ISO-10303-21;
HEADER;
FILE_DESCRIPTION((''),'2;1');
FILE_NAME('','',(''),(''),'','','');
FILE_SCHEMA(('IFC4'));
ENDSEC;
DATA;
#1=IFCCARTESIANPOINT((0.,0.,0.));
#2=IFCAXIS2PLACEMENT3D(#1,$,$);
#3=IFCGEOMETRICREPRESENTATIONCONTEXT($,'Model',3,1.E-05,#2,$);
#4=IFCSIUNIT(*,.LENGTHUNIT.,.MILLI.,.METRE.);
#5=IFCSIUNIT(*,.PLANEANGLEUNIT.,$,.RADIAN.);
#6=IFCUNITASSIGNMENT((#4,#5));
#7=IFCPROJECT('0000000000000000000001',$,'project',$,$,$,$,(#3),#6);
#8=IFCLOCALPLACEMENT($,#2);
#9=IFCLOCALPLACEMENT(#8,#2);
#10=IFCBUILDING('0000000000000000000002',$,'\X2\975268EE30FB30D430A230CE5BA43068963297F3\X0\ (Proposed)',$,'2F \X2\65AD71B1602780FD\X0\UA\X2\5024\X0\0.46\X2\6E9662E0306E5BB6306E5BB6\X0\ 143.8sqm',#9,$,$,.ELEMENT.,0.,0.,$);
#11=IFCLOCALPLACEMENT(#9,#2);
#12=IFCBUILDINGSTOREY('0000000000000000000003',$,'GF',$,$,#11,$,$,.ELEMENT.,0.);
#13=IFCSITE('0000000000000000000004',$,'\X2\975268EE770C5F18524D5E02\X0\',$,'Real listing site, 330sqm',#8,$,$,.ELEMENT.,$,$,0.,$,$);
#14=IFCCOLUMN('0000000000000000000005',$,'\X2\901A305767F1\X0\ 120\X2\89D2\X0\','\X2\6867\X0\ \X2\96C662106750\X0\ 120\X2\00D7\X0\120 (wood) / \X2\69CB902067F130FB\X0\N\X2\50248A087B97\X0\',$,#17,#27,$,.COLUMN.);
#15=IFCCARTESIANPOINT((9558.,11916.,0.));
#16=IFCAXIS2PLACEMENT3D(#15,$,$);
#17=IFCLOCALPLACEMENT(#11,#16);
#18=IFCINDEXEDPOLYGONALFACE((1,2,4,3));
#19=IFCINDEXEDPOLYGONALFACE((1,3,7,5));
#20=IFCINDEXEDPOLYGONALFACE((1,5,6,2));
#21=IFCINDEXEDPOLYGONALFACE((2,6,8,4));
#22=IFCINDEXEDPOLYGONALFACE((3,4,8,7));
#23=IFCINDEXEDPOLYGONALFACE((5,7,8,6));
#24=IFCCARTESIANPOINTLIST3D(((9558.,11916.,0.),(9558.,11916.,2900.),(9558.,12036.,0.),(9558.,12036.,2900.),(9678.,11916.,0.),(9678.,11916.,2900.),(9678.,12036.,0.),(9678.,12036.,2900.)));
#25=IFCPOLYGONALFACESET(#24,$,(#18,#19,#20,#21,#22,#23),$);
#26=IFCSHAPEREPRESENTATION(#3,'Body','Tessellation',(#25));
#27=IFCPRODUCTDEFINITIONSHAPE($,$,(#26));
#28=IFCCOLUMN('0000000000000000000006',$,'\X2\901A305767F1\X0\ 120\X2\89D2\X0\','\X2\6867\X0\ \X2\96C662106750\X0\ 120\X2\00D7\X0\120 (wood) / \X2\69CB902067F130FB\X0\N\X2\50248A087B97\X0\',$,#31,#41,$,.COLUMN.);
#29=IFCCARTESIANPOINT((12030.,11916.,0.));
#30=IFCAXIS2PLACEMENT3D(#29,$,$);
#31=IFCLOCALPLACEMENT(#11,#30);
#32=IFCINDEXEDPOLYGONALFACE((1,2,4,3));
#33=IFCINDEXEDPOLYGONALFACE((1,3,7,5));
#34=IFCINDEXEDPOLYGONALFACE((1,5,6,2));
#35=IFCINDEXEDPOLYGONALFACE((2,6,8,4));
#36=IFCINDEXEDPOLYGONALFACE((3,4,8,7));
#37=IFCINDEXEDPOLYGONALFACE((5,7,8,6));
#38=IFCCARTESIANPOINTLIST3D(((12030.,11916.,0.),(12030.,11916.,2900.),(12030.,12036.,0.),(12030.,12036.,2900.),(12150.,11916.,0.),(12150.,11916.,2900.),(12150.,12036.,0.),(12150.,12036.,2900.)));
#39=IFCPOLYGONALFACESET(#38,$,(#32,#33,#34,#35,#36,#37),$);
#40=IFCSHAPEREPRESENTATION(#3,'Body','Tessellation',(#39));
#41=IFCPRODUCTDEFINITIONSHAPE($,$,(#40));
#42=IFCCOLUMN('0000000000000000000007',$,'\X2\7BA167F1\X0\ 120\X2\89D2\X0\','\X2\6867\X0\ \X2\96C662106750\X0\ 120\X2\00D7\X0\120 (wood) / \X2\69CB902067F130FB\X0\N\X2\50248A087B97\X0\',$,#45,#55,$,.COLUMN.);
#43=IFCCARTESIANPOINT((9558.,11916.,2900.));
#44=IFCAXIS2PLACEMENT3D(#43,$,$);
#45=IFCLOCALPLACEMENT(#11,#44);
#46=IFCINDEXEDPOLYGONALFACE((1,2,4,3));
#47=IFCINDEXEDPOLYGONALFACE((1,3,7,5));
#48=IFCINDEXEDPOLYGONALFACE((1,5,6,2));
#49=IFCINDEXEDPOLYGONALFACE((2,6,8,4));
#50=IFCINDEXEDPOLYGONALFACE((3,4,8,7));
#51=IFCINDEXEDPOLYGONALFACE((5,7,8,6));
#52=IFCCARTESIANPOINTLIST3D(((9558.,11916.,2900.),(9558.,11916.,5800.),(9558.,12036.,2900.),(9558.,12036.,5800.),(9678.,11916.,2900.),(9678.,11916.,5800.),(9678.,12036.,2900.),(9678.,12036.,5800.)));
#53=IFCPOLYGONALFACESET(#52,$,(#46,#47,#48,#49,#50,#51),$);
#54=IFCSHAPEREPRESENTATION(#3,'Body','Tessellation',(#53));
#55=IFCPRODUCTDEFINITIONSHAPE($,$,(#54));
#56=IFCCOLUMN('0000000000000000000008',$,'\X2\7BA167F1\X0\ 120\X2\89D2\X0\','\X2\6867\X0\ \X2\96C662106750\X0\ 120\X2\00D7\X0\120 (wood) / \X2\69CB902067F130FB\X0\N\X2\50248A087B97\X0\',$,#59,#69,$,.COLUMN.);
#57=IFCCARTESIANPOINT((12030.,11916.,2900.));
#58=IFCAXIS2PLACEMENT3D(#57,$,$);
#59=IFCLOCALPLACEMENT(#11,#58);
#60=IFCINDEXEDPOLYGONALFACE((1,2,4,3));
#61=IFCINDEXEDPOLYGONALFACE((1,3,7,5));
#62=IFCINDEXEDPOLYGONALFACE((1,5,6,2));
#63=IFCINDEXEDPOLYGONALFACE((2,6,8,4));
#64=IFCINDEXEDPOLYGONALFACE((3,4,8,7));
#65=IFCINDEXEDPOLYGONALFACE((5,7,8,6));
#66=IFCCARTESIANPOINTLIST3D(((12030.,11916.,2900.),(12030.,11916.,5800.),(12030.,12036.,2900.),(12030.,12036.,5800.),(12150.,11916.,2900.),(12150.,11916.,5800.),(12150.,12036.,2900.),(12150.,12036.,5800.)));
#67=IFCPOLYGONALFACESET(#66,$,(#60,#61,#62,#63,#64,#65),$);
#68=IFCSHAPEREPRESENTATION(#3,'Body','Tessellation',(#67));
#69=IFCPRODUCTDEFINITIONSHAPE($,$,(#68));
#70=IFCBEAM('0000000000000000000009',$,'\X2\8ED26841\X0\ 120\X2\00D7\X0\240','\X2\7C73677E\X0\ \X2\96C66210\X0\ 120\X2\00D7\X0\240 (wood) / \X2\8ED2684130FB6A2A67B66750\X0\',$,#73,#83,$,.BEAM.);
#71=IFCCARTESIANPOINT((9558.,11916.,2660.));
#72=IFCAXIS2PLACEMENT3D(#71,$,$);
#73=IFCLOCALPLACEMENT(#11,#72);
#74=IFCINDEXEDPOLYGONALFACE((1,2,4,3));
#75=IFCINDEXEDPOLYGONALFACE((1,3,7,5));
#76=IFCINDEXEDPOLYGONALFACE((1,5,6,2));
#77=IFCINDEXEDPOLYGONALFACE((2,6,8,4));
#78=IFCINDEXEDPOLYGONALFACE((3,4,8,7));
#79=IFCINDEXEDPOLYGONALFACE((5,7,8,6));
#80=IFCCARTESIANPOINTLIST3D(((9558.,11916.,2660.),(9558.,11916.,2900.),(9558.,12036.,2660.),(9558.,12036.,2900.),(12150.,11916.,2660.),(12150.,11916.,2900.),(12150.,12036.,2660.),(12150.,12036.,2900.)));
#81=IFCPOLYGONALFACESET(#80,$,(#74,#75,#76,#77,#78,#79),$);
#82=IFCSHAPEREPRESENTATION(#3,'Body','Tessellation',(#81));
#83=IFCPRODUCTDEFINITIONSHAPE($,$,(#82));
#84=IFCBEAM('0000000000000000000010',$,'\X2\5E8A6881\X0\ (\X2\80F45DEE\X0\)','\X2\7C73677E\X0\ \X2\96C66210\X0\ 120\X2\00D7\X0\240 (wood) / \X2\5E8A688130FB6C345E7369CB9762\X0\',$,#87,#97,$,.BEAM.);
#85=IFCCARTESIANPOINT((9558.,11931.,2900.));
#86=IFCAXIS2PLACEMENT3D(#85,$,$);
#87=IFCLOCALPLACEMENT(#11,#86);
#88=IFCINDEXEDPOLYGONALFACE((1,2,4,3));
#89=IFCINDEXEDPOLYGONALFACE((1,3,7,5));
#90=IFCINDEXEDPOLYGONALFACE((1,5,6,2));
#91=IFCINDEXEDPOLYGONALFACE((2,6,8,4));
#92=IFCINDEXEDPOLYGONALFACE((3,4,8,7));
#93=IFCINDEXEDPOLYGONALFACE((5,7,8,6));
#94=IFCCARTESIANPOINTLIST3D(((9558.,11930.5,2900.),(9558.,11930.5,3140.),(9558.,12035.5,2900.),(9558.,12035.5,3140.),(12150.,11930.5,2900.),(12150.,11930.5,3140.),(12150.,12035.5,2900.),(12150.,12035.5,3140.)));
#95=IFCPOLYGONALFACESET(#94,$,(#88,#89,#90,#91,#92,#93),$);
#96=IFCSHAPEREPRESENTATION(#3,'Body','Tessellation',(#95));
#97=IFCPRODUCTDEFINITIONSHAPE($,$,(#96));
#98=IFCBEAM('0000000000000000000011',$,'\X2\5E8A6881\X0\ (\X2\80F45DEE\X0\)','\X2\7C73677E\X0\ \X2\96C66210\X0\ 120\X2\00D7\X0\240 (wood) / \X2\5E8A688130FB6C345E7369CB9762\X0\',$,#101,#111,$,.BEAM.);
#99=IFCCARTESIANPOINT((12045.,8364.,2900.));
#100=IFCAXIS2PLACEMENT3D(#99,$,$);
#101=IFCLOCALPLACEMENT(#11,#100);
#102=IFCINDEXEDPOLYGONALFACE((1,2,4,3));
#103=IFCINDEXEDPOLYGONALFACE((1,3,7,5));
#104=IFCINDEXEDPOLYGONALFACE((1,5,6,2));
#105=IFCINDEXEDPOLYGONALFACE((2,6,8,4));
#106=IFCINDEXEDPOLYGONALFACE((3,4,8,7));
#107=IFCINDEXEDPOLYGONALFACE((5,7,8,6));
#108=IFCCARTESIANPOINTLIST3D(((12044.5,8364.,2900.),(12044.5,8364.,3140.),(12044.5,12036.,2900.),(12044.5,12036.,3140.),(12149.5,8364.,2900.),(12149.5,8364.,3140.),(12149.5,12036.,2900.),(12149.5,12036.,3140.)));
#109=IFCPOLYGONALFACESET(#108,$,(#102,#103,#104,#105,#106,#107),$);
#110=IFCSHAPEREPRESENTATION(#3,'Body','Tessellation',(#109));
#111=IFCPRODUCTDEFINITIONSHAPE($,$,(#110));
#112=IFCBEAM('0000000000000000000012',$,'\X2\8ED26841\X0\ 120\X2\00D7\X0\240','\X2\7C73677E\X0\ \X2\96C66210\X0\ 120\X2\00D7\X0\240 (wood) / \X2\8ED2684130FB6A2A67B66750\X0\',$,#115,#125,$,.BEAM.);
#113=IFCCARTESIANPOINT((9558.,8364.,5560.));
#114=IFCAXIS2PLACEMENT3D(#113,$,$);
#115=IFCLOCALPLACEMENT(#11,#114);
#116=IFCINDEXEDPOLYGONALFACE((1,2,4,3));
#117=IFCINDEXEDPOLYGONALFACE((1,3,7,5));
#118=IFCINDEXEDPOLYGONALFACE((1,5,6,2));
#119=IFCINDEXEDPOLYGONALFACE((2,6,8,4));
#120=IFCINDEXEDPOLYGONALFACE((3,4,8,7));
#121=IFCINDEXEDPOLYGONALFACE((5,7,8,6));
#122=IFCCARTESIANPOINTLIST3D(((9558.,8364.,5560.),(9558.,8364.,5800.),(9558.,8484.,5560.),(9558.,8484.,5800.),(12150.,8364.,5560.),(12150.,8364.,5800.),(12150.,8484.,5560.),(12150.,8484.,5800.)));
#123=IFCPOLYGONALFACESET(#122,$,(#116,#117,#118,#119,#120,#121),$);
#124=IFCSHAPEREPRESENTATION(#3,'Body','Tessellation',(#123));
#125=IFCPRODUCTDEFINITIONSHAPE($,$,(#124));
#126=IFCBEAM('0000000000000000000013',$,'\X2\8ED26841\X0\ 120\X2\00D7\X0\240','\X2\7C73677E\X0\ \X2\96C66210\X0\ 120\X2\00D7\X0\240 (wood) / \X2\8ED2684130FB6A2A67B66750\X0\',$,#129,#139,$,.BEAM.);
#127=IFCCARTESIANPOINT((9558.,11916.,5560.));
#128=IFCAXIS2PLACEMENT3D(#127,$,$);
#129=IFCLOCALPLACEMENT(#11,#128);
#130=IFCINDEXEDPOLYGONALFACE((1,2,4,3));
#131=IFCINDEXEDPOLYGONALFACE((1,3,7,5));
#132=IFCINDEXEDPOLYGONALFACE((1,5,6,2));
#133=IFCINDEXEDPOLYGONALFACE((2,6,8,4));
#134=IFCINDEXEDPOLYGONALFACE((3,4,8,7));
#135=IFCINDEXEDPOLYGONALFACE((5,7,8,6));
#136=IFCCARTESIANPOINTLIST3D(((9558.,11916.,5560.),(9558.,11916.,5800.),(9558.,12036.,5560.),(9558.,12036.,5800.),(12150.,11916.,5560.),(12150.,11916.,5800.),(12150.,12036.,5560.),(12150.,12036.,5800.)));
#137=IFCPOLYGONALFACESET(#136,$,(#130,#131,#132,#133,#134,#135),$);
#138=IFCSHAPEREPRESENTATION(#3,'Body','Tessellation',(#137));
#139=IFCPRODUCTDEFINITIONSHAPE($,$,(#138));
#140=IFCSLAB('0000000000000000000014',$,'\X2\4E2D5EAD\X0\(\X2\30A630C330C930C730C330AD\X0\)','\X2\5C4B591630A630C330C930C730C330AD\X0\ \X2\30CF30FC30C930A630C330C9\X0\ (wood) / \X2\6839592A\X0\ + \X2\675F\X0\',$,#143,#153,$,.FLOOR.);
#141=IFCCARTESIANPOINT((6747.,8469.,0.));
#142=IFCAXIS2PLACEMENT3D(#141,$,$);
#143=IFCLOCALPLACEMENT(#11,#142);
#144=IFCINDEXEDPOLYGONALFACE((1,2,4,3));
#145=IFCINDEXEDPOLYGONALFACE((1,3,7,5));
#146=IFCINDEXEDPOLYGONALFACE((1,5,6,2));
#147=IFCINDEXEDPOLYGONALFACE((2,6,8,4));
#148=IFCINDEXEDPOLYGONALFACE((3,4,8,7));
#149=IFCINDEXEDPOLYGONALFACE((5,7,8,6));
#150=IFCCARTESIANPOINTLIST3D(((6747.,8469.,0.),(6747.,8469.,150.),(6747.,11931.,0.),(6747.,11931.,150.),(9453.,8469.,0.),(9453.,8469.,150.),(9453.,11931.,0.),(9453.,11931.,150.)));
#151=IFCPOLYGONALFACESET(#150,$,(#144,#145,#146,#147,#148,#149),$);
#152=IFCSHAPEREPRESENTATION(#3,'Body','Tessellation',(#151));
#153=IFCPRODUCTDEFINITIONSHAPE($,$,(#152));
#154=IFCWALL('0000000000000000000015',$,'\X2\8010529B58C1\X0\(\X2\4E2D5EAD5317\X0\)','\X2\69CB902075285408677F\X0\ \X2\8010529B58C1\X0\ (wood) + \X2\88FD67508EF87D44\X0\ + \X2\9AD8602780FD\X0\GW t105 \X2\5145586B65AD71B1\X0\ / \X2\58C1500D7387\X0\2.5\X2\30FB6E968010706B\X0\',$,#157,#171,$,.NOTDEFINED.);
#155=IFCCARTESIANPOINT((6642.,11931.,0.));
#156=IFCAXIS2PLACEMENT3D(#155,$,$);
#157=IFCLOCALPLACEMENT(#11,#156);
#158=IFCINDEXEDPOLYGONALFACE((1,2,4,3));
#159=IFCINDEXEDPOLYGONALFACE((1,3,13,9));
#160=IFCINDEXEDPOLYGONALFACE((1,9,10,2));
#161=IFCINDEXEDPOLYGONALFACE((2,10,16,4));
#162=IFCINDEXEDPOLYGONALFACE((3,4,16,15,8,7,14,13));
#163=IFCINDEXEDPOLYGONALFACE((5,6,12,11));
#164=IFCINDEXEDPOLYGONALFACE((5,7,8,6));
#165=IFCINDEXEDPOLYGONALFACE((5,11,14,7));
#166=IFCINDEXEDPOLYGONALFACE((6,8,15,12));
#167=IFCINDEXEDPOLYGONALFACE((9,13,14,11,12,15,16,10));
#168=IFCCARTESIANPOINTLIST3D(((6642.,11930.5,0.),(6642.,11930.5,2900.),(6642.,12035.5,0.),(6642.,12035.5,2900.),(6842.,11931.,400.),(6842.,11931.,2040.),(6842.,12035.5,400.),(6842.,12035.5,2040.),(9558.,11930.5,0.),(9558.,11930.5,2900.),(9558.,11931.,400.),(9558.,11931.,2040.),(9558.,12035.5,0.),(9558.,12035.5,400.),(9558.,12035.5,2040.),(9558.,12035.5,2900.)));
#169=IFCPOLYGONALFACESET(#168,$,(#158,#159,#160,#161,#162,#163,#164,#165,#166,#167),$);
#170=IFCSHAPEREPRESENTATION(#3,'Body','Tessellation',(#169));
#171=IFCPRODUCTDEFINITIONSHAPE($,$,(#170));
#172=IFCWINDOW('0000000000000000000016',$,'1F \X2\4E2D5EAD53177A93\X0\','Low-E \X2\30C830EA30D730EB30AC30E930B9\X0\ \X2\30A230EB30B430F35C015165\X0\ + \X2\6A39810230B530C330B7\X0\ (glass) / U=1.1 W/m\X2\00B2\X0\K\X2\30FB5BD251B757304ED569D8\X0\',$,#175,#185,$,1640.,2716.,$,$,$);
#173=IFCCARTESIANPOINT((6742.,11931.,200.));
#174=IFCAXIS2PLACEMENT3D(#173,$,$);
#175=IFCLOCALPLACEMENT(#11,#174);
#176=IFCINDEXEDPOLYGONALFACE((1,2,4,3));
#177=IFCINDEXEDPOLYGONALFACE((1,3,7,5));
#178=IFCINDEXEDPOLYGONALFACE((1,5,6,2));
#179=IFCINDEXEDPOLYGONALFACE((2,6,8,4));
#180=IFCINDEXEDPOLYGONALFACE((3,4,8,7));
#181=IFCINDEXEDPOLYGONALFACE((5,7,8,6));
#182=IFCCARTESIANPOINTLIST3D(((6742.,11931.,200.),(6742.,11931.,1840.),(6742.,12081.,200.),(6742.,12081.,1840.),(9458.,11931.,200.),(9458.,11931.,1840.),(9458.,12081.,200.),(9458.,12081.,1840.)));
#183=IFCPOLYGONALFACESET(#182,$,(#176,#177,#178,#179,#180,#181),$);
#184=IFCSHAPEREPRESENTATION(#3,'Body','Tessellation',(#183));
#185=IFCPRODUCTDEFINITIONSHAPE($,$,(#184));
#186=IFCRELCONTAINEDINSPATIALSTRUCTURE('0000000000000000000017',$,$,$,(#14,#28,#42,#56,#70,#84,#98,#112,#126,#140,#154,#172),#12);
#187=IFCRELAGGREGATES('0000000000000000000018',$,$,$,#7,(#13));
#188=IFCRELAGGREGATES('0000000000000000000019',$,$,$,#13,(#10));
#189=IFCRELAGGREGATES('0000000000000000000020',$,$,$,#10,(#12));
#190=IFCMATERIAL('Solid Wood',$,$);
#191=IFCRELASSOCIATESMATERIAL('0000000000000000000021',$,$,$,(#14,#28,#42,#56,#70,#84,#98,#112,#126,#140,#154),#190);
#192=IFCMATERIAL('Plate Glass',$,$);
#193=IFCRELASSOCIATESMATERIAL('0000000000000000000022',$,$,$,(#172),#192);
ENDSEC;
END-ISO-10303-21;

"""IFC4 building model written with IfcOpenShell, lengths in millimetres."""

from ifc_helpers import new_model, si_unit, frame, frame_2d, origin, place, context, project, spatial, rectangle, extrude, material, element, fill, save


model = new_model("IFC4")

# Units and contexts
model_context = context("Model", 3, precision=1e-05, world=origin())
ifc_project = project(units=[si_unit("LENGTHUNIT", "METRE", prefix="MILLI"), si_unit("PLANEANGLEUNIT", "RADIAN")], contexts=[model_context])

# Site, building, storey
site_placement = place(None, origin())
site = spatial("IfcSite", under=ifc_project, at=site_placement, Name="青森県弘前市", ObjectType="Real listing site, 330sqm", CompositionType="ELEMENT", RefElevation=0.0)
building_placement = place(site_placement, origin())
building = spatial("IfcBuilding", under=site, at=building_placement, Name="青森・ピアノ室と防音 (Proposed)", ObjectType="2F 断熱性能UA値0.46準拠の家の家 143.8sqm", CompositionType="ELEMENT", ElevationOfRefHeight=0.0, ElevationOfTerrain=0.0)
storey_placement = place(building_placement, origin())
storey = spatial("IfcBuildingStorey", under=building, at=storey_placement, Name="GF", CompositionType="ELEMENT", Elevation=0.0)

# Columns
ifc_material_1 = material(Name="Solid Wood")
column_1_placement = place(storey_placement, frame((9558.0, 11916.0, 0.0)))
element("IfcColumn", 1, at=column_1_placement, inside=storey, material=ifc_material_1, Name="通し柱 120角", Description="桧 集成材 120×120 (wood) / 構造柱・N値計算", PredefinedType="COLUMN", context=model_context, shape_type="SweptSolid", body=[
    extrude(rectangle(XDim=120.0, YDim=120.0, at=frame_2d((60.0, 60.0))), frame((9558.0, 11916.0, 0.0)), (0.0, 0.0, 1.0), 2900.0),
])
column_2_placement = place(storey_placement, frame((12030.0, 11916.0, 0.0)))
element("IfcColumn", 2, at=column_2_placement, inside=storey, material=ifc_material_1, Name="通し柱 120角", Description="桧 集成材 120×120 (wood) / 構造柱・N値計算", PredefinedType="COLUMN", context=model_context, shape_type="SweptSolid", body=[
    extrude(rectangle(XDim=120.0, YDim=120.0, at=frame_2d((60.0, 60.0))), frame((12030.0, 11916.0, 0.0)), (0.0, 0.0, 1.0), 2900.0),
])
column_3_placement = place(storey_placement, frame((9558.0, 11916.0, 2900.0)))
element("IfcColumn", 3, at=column_3_placement, inside=storey, material=ifc_material_1, Name="管柱 120角", Description="桧 集成材 120×120 (wood) / 構造柱・N値計算", PredefinedType="COLUMN", context=model_context, shape_type="SweptSolid", body=[
    extrude(rectangle(XDim=120.0, YDim=120.0, at=frame_2d((60.0, 60.0))), frame((9558.0, 11916.0, 2900.0)), (0.0, 0.0, 1.0), 2900.0),
])
column_4_placement = place(storey_placement, frame((12030.0, 11916.0, 2900.0)))
element("IfcColumn", 4, at=column_4_placement, inside=storey, material=ifc_material_1, Name="管柱 120角", Description="桧 集成材 120×120 (wood) / 構造柱・N値計算", PredefinedType="COLUMN", context=model_context, shape_type="SweptSolid", body=[
    extrude(rectangle(XDim=120.0, YDim=120.0, at=frame_2d((60.0, 60.0))), frame((12030.0, 11916.0, 2900.0)), (0.0, 0.0, 1.0), 2900.0),
])

# Beams
beam_1_placement = place(storey_placement, frame((9558.0, 11916.0, 2660.0)))
element("IfcBeam", 5, at=beam_1_placement, inside=storey, material=ifc_material_1, Name="軒桁 120×240", Description="米松 集成 120×240 (wood) / 軒桁・横架材", PredefinedType="BEAM", context=model_context, shape_type="SweptSolid", body=[
    extrude(rectangle(XDim=2592.0, YDim=120.0, at=frame_2d((1296.0, 60.0))), frame((9558.0, 11916.0, 2660.0)), (0.0, 0.0, 1.0), 240.0),
])
beam_2_placement = place(storey_placement, frame((9558.0, 11931.0, 2900.0)))
element("IfcBeam", 6, at=beam_2_placement, inside=storey, material=ifc_material_1, Name="床梁 (胴差)", Description="米松 集成 120×240 (wood) / 床梁・水平構面", PredefinedType="BEAM", context=model_context, shape_type="SweptSolid", body=[
    extrude(rectangle(XDim=2592.0, YDim=105.0, at=frame_2d((1296.0, 52.0))), frame((9558.0, 11931.0, 2900.0)), (0.0, 0.0, 1.0), 240.0),
])
beam_3_placement = place(storey_placement, frame((12045.0, 8364.0, 2900.0)))
element("IfcBeam", 7, at=beam_3_placement, inside=storey, material=ifc_material_1, Name="床梁 (胴差)", Description="米松 集成 120×240 (wood) / 床梁・水平構面", PredefinedType="BEAM", context=model_context, shape_type="SweptSolid", body=[
    extrude(rectangle(XDim=105.0, YDim=3672.0, at=frame_2d((52.0, 1836.0))), frame((12045.0, 8364.0, 2900.0)), (0.0, 0.0, 1.0), 240.0),
])
beam_4_placement = place(storey_placement, frame((9558.0, 8364.0, 5560.0)))
element("IfcBeam", 8, at=beam_4_placement, inside=storey, material=ifc_material_1, Name="軒桁 120×240", Description="米松 集成 120×240 (wood) / 軒桁・横架材", PredefinedType="BEAM", context=model_context, shape_type="SweptSolid", body=[
    extrude(rectangle(XDim=2592.0, YDim=120.0, at=frame_2d((1296.0, 60.0))), frame((9558.0, 8364.0, 5560.0)), (0.0, 0.0, 1.0), 240.0),
])
beam_5_placement = place(storey_placement, frame((9558.0, 11916.0, 5560.0)))
element("IfcBeam", 9, at=beam_5_placement, inside=storey, material=ifc_material_1, Name="軒桁 120×240", Description="米松 集成 120×240 (wood) / 軒桁・横架材", PredefinedType="BEAM", context=model_context, shape_type="SweptSolid", body=[
    extrude(rectangle(XDim=2592.0, YDim=120.0, at=frame_2d((1296.0, 60.0))), frame((9558.0, 11916.0, 5560.0)), (0.0, 0.0, 1.0), 240.0),
])

# Slab
slab_placement = place(storey_placement, frame((6747.0, 8469.0, 0.0)))
element("IfcSlab", 10, at=slab_placement, inside=storey, material=ifc_material_1, Name="中庭(ウッドデッキ)", Description="屋外ウッドデッキ ハードウッド (wood) / 根太 + 束", PredefinedType="FLOOR", context=model_context, shape_type="SweptSolid", body=[
    extrude(rectangle(XDim=2706.0, YDim=3462.0, at=frame_2d((1353.0, 1731.0))), frame((6747.0, 8469.0, 0.0)), (0.0, 0.0, 1.0), 150.0),
])

# Wall, opening, window
wall_1_placement = place(storey_placement, frame((6642.0, 11931.0, 0.0)))
wall_1 = element("IfcWall", 11, at=wall_1_placement, inside=storey, material=ifc_material_1, Name="耐力壁(中庭北)", Description="構造用合板 耐力壁 (wood) + 製材軸組 + 高性能GW t105 充填断熱 / 壁倍率2.5・準耐火", PredefinedType="NOTDEFINED", context=model_context, shape_type="SweptSolid", body=[
    extrude(rectangle(XDim=2916.0, YDim=105.0, at=frame_2d((1458.0, 52.0))), frame((6642.0, 11931.0, 0.0)), (0.0, 0.0, 1.0), 2900.0),
])
opening_1_placement = place(storey_placement, frame((6742.0, 11931.0, 200.0)))
opening_1 = element("IfcOpeningElement", 12, at=opening_1_placement, cuts=wall_1, PredefinedType="NOTDEFINED", context=model_context, shape_type="SweptSolid", body=[
    extrude(rectangle(XDim=2716.0, YDim=150.0, at=frame_2d((1358.0, 75.0))), frame((6742.0, 11931.0, 200.0)), (0.0, 0.0, 1.0), 1640.0),
])
ifc_material_2 = material(Name="Plate Glass")
window_1_placement = place(storey_placement, frame((6742.0, 11931.0, 200.0)))
window_1 = element("IfcWindow", 13, at=window_1_placement, inside=storey, material=ifc_material_2, Name="1F 中庭北窓", Description="Low-E トリプルガラス アルゴン封入 + 樹脂サッシ (glass) / U=1.1 W/m²K・寒冷地仕様", OverallHeight=1640.0, OverallWidth=2716.0, context=model_context, shape_type="SweptSolid", body=[
    extrude(rectangle(XDim=2716.0, YDim=150.0, at=frame_2d((1358.0, 75.0))), frame((6742.0, 11931.0, 200.0)), (0.0, 0.0, 1.0), 1640.0),
])
fill(opening_1, window_1)

save(model, "model.ifc")
